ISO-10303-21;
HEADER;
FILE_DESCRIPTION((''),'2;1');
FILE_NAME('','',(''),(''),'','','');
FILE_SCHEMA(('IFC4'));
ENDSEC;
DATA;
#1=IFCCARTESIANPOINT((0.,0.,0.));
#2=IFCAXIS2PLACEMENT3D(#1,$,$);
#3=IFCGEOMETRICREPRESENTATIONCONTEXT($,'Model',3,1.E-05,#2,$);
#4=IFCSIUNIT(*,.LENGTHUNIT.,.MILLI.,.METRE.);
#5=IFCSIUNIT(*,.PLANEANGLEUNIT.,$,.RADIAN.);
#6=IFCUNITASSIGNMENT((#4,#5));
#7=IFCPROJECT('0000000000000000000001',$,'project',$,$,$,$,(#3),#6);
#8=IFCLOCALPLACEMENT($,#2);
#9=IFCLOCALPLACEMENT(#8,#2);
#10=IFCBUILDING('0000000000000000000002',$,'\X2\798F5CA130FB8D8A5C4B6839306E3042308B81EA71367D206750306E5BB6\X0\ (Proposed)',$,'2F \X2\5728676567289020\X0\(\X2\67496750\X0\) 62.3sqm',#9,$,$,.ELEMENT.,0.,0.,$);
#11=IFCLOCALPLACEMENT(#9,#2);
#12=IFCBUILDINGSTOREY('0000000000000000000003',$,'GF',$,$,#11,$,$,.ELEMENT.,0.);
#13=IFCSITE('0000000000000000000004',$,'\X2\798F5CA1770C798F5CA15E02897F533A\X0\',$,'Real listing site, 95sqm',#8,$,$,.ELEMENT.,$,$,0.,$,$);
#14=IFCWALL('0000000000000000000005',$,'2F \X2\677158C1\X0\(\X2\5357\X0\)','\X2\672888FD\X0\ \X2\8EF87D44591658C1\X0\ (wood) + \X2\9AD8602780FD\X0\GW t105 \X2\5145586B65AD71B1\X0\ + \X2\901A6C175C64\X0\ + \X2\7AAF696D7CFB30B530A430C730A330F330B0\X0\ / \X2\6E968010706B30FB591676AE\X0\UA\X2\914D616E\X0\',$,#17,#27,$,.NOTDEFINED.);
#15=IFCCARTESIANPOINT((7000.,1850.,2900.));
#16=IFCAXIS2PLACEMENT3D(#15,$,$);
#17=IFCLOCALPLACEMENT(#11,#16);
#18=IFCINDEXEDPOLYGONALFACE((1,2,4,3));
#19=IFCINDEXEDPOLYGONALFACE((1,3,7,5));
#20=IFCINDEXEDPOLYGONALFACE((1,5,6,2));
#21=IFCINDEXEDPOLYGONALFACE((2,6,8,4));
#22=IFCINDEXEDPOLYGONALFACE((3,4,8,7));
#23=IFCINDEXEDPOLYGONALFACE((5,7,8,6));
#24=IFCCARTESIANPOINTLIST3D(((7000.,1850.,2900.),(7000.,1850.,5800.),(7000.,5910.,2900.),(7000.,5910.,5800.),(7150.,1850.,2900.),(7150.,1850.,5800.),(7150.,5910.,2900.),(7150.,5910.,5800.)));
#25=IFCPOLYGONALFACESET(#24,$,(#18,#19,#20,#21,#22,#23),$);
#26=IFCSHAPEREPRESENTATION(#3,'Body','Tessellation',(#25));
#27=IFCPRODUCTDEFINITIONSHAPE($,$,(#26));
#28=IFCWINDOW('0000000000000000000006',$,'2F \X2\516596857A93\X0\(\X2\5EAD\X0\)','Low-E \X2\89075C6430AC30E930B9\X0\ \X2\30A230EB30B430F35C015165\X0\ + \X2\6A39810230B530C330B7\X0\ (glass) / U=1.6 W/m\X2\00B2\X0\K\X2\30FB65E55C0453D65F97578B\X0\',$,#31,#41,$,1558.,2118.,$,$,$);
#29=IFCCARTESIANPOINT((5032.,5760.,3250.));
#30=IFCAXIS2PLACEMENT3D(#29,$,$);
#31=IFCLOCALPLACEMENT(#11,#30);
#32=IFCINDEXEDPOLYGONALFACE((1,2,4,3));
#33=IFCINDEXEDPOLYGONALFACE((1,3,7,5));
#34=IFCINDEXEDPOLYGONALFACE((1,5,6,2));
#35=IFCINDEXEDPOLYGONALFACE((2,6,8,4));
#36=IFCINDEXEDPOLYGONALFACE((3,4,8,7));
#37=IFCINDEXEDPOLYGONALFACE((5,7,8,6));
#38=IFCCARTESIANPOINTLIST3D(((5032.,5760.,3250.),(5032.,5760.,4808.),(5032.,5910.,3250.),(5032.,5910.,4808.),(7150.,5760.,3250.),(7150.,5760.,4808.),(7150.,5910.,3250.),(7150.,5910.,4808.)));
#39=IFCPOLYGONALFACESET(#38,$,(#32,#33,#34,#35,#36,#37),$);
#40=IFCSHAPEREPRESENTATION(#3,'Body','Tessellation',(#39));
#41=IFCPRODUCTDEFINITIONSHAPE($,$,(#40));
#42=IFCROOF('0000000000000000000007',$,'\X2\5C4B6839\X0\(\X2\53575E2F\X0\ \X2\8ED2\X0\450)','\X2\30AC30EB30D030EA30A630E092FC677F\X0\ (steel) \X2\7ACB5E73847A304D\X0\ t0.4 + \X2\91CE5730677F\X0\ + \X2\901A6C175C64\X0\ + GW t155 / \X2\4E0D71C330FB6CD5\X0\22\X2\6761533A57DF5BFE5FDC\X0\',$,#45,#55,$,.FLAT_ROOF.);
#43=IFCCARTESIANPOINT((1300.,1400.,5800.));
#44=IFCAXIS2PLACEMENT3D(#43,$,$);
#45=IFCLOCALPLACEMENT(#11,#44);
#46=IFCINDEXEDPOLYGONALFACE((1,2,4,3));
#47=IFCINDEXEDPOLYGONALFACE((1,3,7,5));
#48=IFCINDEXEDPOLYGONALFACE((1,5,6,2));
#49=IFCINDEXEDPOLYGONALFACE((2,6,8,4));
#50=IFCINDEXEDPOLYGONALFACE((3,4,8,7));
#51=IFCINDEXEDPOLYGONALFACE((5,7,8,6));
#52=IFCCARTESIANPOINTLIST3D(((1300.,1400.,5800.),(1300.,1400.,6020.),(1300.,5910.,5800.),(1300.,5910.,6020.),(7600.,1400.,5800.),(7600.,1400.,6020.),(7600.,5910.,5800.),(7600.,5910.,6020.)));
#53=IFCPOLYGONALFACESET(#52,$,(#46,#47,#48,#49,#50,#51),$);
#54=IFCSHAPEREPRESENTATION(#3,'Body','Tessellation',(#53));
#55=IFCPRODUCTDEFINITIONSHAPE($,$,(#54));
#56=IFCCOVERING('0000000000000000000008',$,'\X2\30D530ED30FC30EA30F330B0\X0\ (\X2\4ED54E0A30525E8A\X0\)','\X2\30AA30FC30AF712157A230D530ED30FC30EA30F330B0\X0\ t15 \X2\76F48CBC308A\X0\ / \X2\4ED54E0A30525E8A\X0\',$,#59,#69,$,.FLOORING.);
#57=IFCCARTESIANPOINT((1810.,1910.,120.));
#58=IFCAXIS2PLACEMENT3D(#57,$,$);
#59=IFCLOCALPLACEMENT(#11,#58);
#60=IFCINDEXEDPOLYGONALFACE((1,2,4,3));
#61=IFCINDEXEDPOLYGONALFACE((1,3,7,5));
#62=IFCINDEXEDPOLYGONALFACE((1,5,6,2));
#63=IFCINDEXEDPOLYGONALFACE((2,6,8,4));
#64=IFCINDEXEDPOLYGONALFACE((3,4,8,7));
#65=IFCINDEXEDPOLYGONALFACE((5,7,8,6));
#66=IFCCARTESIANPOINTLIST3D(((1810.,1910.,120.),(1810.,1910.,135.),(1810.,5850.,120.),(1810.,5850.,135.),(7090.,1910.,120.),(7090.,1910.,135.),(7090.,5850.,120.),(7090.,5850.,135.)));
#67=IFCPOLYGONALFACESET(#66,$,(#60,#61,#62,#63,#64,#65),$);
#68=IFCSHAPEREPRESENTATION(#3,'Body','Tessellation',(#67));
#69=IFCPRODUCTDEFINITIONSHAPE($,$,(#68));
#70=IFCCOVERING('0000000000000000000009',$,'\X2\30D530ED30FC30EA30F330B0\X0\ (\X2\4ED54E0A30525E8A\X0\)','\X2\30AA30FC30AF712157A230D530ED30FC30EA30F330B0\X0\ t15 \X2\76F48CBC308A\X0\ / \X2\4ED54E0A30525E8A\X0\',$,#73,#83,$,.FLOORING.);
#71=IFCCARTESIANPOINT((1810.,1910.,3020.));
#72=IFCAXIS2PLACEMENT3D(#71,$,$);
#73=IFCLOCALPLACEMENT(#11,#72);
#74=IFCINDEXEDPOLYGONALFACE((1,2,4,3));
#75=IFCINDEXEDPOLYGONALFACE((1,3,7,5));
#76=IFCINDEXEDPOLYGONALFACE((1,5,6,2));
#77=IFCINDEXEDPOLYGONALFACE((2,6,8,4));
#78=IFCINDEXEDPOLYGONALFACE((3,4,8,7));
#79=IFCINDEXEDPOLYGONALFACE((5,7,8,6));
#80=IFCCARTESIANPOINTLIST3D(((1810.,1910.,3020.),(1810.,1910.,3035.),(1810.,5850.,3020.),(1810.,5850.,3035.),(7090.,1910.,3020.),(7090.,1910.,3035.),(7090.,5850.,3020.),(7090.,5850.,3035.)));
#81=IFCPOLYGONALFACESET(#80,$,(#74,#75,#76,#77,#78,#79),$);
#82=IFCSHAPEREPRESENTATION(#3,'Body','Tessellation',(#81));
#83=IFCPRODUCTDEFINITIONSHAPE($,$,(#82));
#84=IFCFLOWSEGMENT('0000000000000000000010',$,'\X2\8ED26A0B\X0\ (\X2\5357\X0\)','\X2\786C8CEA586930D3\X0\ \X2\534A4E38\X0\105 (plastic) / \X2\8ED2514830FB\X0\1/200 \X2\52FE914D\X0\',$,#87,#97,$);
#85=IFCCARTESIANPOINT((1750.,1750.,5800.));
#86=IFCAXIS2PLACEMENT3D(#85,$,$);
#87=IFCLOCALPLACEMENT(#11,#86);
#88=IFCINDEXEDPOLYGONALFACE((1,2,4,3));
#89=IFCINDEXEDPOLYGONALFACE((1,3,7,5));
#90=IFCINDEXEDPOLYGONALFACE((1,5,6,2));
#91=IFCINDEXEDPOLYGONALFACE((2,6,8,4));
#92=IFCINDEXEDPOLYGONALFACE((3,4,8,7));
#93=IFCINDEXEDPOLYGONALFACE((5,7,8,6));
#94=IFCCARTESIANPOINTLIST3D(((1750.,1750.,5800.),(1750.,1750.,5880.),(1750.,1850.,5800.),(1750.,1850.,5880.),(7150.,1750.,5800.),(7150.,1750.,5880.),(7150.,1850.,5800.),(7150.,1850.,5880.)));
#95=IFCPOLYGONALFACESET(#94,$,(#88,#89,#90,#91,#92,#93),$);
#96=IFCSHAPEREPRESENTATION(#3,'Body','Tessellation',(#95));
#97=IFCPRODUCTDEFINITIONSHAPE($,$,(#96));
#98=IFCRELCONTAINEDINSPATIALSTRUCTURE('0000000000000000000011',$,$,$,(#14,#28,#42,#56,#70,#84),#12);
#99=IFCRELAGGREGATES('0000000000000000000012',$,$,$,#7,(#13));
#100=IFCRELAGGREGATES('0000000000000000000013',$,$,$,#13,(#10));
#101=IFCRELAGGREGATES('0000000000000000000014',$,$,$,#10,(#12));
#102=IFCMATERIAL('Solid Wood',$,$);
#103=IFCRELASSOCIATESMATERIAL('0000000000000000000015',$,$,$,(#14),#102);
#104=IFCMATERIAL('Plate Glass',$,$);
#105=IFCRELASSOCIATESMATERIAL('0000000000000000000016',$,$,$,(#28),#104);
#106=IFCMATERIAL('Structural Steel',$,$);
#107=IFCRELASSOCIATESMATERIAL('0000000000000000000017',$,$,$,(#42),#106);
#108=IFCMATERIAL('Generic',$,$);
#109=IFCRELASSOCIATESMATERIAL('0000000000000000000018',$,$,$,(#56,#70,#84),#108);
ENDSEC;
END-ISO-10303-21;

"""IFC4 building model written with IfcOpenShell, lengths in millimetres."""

from ifc_helpers import new_model, si_unit, frame, frame_2d, origin, place, context, project, spatial, rectangle, extrude, material, element, fill, save


model = new_model("IFC4")

# Units and contexts
model_context = context("Model", 3, precision=1e-05, world=origin())
ifc_project = project(units=[si_unit("LENGTHUNIT", "METRE", prefix="MILLI"), si_unit("PLANEANGLEUNIT", "RADIAN")], contexts=[model_context])

# Site, building, storey
site_placement = place(None, origin())
site = spatial("IfcSite", under=ifc_project, at=site_placement, Name="福岡県福岡市西区", ObjectType="Real listing site, 95sqm", CompositionType="ELEMENT", RefElevation=0.0)
building_placement = place(site_placement, origin())
building = spatial("IfcBuilding", under=site, at=building_placement, Name="福岡・越屋根のある自然素材の家 (Proposed)", ObjectType="2F 在来木造(杉材) 62.3sqm", CompositionType="ELEMENT", ElevationOfRefHeight=0.0, ElevationOfTerrain=0.0)
storey_placement = place(building_placement, origin())
storey = spatial("IfcBuildingStorey", under=building, at=storey_placement, Name="GF", CompositionType="ELEMENT", Elevation=0.0)

# Shared definitions
ifc_material_1 = material(Name="Solid Wood")

# Wall, opening, window
ifc_material_2 = material(Name="Plate Glass")
wall_1_placement = place(storey_placement, frame((7000.0, 1850.0, 2900.0)))
wall_1 = element("IfcWall", 1, at=wall_1_placement, inside=storey, material=ifc_material_1, Name="2F 東壁(南)", Description="木製 軸組外壁 (wood) + 高性能GW t105 充填断熱 + 通気層 + 窯業系サイディング / 準耐火・外皮UA配慮", PredefinedType="NOTDEFINED", context=model_context, shape_type="SweptSolid", body=[
    extrude(rectangle(XDim=150.0, YDim=4060.0, at=frame_2d((75.0, 2030.0))), frame((7000.0, 1850.0, 2900.0)), (0.0, 0.0, 1.0), 2900.0),
])
opening_1_placement = place(storey_placement, frame((5032.0, 5760.0, 3250.0)))
opening_1 = element("IfcOpeningElement", 2, at=opening_1_placement, cuts=wall_1, PredefinedType="NOTDEFINED", context=model_context, shape_type="SweptSolid", body=[
    extrude(rectangle(XDim=2118.0, YDim=150.0, at=frame_2d((1059.0, 75.0))), frame((5032.0, 5760.0, 3250.0)), (0.0, 0.0, 1.0), 1558.0),
])
window_1_placement = place(storey_placement, frame((5032.0, 5760.0, 3250.0)))
window_1 = element("IfcWindow", 3, at=window_1_placement, inside=storey, material=ifc_material_2, Name="2F 入隅窓(庭)", Description="Low-E 複層ガラス アルゴン封入 + 樹脂サッシ (glass) / U=1.6 W/m²K・日射取得型", OverallHeight=1558.0, OverallWidth=2118.0, context=model_context, shape_type="SweptSolid", body=[
    extrude(rectangle(XDim=2118.0, YDim=150.0, at=frame_2d((1059.0, 75.0))), frame((5032.0, 5760.0, 3250.0)), (0.0, 0.0, 1.0), 1558.0),
])
fill(opening_1, window_1)

# Roof
ifc_material_3 = material(Name="Structural Steel")
for number, where, name in (
    (4, (1300.0, 1400.0, 5800.0), "屋根(南帯 軒450)"),
):
    element("IfcRoof", number, at=place(storey_placement, frame(where)), inside=storey, material=ifc_material_3, Name=name, Description="ガルバリウム鋼板 (steel) 立平葺き t0.4 + 野地板 + 通気層 + GW t155 / 不燃・法22条区域対応", PredefinedType="FLAT_ROOF", context=model_context, shape_type="SweptSolid", body=[
        extrude(rectangle(XDim=6300.0, YDim=4510.0, at=frame_2d((3150.0, 2255.0))), frame((1300.0, 1400.0, 5800.0)), (0.0, 0.0, 1.0), 220.0),
    ])

# Coverings
ifc_material_4 = material(Name="Generic")
covering_1_placement = place(storey_placement, frame((1810.0, 1910.0, 120.0)))
element("IfcCovering", 5, at=covering_1_placement, inside=storey, material=ifc_material_4, Name="フローリング (仕上げ床)", Description="オーク無垢フローリング t15 直貼り / 仕上げ床", PredefinedType="FLOORING", context=model_context, shape_type="SweptSolid", body=[
    extrude(rectangle(XDim=5280.0, YDim=3940.0, at=frame_2d((2640.0, 1970.0))), frame((1810.0, 1910.0, 120.0)), (0.0, 0.0, 1.0), 15.0),
])
covering_2_placement = place(storey_placement, frame((1810.0, 1910.0, 3020.0)))
element("IfcCovering", 6, at=covering_2_placement, inside=storey, material=ifc_material_4, Name="フローリング (仕上げ床)", Description="オーク無垢フローリング t15 直貼り / 仕上げ床", PredefinedType="FLOORING", context=model_context, shape_type="SweptSolid", body=[
    extrude(rectangle(XDim=5280.0, YDim=3940.0, at=frame_2d((2640.0, 1970.0))), frame((1810.0, 1910.0, 3020.0)), (0.0, 0.0, 1.0), 15.0),
])

# Flow segment
flow_segment_placement = place(storey_placement, frame((1750.0, 1750.0, 5800.0)))
element("IfcFlowSegment", 7, at=flow_segment_placement, inside=storey, material=ifc_material_4, Name="軒樋 (南)", Description="硬質塩ビ 半丸105 (plastic) / 軒先・1/200 勾配", context=model_context, shape_type="SweptSolid", body=[
    extrude(rectangle(XDim=5400.0, YDim=100.0, at=frame_2d((2700.0, 50.0))), frame((1750.0, 1750.0, 5800.0)), (0.0, 0.0, 1.0), 80.0),
])

save(model, "model.ifc")
